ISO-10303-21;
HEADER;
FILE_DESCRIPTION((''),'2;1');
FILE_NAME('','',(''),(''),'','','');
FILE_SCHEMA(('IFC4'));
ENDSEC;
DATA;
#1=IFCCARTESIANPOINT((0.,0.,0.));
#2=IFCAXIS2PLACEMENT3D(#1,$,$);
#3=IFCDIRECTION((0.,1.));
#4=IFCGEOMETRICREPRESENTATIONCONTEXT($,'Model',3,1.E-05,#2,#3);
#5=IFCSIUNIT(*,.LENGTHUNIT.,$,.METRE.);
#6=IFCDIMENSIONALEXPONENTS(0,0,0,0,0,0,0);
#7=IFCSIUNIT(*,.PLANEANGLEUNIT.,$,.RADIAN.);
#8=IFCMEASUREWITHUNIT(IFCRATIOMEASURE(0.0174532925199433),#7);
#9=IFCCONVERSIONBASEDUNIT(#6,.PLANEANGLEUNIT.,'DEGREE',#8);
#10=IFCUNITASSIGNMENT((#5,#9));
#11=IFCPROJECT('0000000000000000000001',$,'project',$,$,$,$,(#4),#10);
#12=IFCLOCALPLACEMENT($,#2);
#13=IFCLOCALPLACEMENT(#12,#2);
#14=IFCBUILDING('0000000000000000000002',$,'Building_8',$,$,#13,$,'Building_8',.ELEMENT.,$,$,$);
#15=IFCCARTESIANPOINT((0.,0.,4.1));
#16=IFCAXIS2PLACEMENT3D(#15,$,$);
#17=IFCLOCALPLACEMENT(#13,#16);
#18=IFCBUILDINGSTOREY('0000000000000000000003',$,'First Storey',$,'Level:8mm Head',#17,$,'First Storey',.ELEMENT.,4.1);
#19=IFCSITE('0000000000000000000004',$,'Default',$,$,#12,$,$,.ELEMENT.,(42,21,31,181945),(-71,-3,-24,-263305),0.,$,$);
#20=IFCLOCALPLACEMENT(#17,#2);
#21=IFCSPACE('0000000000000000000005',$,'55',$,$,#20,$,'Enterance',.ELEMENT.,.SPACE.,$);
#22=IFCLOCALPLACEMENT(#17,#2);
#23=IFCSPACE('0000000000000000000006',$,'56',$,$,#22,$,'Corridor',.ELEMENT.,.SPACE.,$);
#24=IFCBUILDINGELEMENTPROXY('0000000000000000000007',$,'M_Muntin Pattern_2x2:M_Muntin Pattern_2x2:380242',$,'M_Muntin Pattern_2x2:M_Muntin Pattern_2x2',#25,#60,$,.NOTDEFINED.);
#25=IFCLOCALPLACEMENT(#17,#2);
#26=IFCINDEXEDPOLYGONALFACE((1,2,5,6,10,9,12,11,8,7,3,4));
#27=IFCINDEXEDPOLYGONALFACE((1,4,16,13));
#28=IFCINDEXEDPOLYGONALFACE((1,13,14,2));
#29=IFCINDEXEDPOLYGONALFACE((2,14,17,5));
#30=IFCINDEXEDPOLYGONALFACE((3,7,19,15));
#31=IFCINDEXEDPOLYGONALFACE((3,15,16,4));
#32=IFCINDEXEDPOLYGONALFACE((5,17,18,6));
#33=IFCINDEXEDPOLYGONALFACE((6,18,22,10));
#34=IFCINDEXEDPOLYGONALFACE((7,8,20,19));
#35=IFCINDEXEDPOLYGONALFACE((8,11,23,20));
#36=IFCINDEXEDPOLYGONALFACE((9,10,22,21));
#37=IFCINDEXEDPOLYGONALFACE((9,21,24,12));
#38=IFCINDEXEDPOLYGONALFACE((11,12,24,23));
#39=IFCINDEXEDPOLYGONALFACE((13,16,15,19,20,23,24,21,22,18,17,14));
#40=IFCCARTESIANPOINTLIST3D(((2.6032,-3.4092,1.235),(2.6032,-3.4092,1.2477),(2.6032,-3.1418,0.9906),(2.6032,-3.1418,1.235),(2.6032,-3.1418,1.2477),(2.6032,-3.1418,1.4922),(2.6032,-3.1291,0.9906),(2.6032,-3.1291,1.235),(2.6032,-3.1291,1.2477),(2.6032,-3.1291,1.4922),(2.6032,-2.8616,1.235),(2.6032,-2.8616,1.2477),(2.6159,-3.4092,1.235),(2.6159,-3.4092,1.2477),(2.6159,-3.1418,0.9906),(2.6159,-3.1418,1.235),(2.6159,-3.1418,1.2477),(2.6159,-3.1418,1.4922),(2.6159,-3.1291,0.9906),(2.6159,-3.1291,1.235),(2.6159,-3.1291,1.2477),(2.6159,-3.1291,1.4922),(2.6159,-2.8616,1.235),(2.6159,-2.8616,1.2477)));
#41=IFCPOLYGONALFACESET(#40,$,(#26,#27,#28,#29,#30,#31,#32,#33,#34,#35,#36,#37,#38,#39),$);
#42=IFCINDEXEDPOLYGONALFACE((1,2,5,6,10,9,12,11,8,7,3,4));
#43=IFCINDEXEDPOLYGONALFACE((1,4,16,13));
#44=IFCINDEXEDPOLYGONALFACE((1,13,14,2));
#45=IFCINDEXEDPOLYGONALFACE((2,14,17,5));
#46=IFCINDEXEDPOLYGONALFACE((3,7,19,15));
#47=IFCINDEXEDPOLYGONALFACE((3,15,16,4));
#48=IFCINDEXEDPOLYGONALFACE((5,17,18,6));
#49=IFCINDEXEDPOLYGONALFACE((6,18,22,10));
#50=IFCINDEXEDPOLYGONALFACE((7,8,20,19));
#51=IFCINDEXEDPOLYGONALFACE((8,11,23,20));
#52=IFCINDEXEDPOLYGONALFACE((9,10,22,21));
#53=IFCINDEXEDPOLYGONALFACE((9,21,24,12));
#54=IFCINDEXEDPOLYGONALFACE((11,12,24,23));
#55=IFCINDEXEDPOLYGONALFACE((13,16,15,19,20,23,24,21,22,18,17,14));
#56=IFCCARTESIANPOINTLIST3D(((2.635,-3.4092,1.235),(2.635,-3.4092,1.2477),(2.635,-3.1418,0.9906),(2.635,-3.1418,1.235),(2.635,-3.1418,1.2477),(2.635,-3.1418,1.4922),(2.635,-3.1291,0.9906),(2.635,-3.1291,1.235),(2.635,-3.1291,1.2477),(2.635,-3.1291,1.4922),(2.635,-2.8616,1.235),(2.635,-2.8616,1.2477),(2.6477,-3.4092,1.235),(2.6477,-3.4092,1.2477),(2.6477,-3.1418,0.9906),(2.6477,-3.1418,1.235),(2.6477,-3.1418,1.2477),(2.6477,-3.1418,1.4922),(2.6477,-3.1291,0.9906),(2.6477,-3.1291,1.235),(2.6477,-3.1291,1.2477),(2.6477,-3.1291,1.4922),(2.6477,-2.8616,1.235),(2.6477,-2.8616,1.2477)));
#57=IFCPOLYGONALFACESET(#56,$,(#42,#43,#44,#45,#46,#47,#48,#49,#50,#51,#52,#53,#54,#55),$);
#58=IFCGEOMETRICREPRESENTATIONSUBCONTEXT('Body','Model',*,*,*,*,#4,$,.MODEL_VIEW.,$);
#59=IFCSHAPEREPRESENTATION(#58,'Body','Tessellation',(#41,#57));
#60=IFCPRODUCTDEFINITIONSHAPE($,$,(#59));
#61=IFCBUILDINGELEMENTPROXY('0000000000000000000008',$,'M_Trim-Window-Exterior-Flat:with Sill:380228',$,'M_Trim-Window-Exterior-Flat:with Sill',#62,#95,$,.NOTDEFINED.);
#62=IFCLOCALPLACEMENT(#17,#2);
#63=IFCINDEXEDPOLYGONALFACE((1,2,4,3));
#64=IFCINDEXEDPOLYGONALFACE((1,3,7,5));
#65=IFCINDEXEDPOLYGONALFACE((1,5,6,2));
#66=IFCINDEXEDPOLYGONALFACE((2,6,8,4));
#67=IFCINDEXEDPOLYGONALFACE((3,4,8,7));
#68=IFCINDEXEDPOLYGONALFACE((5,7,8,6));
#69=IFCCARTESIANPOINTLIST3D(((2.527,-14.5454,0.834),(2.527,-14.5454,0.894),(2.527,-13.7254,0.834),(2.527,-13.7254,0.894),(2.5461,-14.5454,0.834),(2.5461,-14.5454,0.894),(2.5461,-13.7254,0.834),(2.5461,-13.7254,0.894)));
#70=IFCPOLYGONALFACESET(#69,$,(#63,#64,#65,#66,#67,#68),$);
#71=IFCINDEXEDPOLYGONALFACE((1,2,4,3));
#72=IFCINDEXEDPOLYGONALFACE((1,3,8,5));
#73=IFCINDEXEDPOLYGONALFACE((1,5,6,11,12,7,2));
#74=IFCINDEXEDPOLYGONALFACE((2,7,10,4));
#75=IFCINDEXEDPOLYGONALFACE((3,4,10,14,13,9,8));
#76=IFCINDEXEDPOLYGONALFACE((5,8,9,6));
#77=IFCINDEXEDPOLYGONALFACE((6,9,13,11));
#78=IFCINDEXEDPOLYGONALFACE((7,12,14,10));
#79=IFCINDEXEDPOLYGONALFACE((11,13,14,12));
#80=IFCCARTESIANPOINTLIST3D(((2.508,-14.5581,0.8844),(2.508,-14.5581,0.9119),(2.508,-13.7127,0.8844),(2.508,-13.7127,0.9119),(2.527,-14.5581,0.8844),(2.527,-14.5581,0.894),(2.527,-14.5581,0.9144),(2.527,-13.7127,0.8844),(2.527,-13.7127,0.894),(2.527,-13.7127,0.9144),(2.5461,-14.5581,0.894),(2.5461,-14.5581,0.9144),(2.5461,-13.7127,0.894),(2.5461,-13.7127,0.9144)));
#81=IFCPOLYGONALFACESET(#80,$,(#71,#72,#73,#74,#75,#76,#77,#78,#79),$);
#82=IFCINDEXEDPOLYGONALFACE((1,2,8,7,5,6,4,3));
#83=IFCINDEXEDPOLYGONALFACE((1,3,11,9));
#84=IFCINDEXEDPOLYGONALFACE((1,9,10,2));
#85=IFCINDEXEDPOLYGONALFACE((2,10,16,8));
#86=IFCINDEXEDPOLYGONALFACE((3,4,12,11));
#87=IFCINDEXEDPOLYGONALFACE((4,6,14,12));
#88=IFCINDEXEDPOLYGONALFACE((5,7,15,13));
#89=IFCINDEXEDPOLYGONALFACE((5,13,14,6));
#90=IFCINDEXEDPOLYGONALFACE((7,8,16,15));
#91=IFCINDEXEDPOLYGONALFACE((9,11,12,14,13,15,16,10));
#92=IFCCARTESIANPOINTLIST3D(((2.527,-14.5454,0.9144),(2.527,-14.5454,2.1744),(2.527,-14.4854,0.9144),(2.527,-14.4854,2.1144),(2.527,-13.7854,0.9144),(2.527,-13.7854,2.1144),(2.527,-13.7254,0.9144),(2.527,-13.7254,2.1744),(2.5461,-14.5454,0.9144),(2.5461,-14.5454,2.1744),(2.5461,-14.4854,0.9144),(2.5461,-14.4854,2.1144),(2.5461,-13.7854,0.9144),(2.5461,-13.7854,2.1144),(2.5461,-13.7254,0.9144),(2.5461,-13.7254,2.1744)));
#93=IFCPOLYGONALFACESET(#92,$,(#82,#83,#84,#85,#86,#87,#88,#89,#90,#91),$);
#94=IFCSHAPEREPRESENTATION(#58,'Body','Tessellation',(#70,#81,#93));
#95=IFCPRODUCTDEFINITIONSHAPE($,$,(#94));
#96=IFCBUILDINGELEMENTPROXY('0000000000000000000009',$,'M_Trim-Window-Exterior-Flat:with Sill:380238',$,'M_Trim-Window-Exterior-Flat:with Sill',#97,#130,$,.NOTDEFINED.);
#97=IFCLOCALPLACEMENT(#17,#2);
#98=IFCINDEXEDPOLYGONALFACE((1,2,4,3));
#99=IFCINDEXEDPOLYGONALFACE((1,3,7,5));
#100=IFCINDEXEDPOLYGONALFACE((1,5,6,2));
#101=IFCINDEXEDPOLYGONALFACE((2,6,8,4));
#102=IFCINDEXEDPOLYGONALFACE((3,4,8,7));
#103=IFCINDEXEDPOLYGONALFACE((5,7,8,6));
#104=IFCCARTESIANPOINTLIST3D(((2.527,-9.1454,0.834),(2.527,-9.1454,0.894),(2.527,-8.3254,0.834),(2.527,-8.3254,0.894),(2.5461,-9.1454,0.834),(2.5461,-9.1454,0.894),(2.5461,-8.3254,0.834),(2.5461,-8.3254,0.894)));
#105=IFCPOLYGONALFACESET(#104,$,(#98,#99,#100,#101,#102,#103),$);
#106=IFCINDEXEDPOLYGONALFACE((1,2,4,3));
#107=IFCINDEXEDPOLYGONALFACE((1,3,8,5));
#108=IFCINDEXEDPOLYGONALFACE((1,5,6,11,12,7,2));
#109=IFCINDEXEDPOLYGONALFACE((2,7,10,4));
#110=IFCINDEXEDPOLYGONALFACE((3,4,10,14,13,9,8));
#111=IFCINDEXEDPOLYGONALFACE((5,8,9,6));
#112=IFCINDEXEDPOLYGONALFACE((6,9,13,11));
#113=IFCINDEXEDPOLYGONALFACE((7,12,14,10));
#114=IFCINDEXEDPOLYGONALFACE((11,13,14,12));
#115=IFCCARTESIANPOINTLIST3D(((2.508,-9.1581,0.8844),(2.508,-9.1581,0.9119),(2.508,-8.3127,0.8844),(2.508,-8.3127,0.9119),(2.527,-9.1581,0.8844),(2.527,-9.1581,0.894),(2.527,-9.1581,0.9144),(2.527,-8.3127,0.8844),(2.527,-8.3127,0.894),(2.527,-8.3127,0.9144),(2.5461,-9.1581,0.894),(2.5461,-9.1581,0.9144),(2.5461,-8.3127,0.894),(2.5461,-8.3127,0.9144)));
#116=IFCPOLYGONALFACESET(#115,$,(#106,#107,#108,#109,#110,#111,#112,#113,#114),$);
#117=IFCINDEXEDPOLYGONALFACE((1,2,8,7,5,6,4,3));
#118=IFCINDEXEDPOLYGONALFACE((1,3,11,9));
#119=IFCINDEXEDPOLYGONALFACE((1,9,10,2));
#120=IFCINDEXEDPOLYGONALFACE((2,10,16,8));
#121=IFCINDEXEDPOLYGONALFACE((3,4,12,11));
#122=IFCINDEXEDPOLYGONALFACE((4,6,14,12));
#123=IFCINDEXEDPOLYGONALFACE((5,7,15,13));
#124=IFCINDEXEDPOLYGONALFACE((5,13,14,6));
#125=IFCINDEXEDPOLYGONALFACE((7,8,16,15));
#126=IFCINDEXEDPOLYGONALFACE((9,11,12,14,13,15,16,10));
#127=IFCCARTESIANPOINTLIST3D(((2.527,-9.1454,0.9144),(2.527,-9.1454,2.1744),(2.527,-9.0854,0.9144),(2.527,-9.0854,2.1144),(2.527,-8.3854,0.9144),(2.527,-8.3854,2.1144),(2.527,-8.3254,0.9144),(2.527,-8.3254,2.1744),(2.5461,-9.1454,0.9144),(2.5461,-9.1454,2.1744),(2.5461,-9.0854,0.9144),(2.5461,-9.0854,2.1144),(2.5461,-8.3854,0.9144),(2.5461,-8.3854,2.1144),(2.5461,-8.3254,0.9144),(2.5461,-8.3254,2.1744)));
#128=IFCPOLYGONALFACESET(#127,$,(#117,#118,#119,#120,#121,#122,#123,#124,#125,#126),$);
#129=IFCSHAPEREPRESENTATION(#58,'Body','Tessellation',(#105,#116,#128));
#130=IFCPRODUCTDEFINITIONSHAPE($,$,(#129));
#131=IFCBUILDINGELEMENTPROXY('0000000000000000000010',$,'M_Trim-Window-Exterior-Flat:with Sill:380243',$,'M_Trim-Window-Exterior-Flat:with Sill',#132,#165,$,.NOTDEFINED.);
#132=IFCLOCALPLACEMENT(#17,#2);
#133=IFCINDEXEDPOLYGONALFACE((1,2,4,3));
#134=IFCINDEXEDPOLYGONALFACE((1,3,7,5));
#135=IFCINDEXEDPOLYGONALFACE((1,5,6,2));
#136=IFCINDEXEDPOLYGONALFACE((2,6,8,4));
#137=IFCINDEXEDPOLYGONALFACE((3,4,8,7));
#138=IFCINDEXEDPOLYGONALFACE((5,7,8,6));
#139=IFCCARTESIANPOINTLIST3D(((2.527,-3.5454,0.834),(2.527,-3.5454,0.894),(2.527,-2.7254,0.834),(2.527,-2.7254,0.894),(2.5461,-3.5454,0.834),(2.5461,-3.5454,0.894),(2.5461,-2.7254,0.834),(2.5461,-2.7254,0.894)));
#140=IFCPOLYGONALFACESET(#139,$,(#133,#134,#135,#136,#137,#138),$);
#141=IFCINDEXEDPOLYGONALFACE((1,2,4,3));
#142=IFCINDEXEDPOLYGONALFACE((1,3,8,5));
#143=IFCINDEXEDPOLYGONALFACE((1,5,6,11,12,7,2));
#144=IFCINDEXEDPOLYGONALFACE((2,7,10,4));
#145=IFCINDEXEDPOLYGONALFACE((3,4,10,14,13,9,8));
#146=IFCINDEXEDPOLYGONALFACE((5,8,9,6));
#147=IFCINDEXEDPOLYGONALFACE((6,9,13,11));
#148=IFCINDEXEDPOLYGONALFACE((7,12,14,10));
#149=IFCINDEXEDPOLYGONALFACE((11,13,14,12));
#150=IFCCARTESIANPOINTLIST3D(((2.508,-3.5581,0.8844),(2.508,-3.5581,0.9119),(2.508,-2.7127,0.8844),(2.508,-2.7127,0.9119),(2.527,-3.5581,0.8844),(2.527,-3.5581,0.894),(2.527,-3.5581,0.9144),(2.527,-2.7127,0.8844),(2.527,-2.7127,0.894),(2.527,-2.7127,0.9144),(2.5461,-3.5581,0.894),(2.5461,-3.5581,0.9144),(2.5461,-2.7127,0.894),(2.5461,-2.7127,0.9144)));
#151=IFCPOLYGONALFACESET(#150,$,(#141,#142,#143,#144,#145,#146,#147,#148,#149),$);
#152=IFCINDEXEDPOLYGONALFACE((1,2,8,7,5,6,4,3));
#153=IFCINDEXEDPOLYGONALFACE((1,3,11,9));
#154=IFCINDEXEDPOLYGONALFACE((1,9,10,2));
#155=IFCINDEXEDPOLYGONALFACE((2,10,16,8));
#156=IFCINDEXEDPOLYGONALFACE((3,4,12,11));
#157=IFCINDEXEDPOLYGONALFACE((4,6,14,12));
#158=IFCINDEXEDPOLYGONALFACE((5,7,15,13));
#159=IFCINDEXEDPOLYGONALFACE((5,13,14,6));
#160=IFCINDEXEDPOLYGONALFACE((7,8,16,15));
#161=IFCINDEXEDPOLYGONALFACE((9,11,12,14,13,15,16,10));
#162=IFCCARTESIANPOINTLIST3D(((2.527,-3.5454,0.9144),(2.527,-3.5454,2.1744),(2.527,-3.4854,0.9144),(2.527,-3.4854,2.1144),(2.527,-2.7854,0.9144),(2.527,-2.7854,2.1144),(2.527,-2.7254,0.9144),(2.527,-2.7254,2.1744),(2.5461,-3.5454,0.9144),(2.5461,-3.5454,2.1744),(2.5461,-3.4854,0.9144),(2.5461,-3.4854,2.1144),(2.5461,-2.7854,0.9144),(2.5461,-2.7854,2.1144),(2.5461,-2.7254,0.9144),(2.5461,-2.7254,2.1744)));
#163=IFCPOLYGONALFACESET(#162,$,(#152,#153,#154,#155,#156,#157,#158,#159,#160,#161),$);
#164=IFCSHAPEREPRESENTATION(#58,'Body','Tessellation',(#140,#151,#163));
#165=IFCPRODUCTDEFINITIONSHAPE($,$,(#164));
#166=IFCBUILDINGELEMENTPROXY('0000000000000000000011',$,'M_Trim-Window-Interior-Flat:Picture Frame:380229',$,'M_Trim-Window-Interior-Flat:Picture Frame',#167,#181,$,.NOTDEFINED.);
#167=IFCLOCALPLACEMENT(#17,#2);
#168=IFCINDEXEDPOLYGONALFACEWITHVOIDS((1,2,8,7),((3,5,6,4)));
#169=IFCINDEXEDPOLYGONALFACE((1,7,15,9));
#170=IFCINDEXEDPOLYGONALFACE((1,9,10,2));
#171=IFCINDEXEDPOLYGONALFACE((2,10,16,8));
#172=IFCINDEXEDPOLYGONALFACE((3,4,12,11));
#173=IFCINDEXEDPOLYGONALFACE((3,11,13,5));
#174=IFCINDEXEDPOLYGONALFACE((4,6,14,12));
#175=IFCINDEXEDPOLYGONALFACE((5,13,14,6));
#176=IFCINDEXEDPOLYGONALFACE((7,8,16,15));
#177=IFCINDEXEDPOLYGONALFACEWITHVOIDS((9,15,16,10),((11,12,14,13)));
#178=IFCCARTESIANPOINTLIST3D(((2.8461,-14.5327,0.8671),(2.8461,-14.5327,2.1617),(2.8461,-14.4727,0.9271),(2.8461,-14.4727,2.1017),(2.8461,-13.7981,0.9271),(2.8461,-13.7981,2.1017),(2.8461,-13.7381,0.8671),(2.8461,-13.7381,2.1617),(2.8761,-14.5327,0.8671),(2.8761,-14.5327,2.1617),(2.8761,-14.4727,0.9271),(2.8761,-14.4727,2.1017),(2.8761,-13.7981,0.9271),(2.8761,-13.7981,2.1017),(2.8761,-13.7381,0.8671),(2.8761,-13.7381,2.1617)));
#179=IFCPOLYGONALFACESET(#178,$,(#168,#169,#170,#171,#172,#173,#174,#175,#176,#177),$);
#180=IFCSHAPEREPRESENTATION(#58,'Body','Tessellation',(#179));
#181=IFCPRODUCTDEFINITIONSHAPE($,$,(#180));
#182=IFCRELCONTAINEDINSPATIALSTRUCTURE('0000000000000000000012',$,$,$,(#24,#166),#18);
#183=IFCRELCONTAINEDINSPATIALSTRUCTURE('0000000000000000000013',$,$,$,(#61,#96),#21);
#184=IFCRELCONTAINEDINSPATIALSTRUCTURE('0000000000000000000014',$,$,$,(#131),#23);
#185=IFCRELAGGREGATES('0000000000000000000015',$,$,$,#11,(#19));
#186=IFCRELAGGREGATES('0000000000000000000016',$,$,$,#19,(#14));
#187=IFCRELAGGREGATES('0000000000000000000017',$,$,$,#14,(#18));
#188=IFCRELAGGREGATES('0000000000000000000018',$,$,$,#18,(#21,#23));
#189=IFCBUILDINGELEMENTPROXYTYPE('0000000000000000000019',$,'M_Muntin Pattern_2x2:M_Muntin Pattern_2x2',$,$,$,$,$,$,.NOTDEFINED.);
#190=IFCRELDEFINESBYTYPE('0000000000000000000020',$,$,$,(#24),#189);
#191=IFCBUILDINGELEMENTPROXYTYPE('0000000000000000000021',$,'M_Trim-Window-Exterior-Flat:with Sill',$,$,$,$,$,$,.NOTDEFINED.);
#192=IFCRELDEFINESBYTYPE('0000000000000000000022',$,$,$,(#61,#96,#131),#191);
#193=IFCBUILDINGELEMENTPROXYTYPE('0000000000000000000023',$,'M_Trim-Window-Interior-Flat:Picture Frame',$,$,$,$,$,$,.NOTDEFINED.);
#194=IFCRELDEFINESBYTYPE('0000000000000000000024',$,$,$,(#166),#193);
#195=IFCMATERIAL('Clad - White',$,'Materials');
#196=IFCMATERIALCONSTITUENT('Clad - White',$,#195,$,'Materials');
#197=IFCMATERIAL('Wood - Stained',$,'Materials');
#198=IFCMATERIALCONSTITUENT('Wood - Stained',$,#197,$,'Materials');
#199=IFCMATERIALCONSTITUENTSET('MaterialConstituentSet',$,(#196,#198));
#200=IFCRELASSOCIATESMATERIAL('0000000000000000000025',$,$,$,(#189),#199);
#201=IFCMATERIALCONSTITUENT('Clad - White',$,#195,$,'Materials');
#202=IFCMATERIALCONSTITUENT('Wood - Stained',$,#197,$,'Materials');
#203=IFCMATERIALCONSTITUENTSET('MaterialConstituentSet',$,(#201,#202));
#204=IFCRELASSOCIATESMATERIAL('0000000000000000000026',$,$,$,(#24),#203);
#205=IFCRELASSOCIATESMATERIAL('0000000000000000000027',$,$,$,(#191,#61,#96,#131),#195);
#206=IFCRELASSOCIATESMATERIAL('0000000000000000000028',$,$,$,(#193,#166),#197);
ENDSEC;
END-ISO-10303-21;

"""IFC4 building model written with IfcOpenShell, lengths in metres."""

from ifc_helpers import new_model, entity, si_unit, converted_unit, direction, frame, origin, place, context, subcontext, project, spatial, indexed_curve, outline, extrude, source, transform, mapped, material, constituent, constituent_set, type_object, type_shapes, element, save


model = new_model("IFC4")

# Units and contexts
model_context = context("Model", 3, precision=1e-05, world=origin(), true_north=direction((0.0, 1.0)))
body_context = subcontext(model_context, "Body", "Model", "MODEL_VIEW")
ifc_project = project(units=[si_unit("LENGTHUNIT", "METRE"), converted_unit("PLANEANGLEUNIT", "DEGREE", entity("IfcRatioMeasure", 0.0174532925199433), si_unit("PLANEANGLEUNIT", "RADIAN"), dimensions=[0, 0, 0, 0, 0, 0, 0])], contexts=[model_context])

# Site, building, storey
site_placement = place(None, origin())
site = spatial("IfcSite", under=ifc_project, at=site_placement, Name="Default", CompositionType="ELEMENT", RefLatitude=(42, 21, 31, 181945), RefLongitude=(-71, -3, -24, -263305), RefElevation=0.0)
building_placement = place(site_placement, origin())
building = spatial("IfcBuilding", under=site, at=building_placement, Name="Building_8", LongName="Building_8", CompositionType="ELEMENT")
storey_placement = place(building_placement, frame((0.0, 0.0, 4.1)))
storey = spatial("IfcBuildingStorey", under=building, at=storey_placement, Name="First Storey", ObjectType="Level:8mm Head", LongName="First Storey", CompositionType="ELEMENT", Elevation=4.1)

# Building element proxy
ifc_material_1 = material(Name="Clad - White", Category="Materials")
ifc_material_2 = material(Name="Wood - Stained", Category="Materials")
ifc_constituent_1 = constituent(ifc_material_1, Name="Clad - White", Category="Materials")
ifc_constituent_2 = constituent(ifc_material_2, Name="Wood - Stained", Category="Materials")
ifc_constituent_set_1 = constituent_set(constituents=[ifc_constituent_1, ifc_constituent_2], Name="MaterialConstituentSet")
building_element_proxy_type_1 = type_object("IfcBuildingElementProxyType", Name="M_Muntin Pattern_2x2:M_Muntin Pattern_2x2", PredefinedType="NOTDEFINED", material=ifc_constituent_set_1)
shared_shape_1 = source(origin(), body_context, "Body", "SweptSolid", [
    extrude(outline(indexed_curve([(0.0064, -0.0064), (0.2508, -0.0064), (0.2508, 0.0063), (0.0064, 0.0063), (0.0064, 0.2738), (-0.0063, 0.2738), (-0.0063, 0.0063), (-0.2508, 0.0063), (-0.2508, -0.0064), (-0.0063, -0.0064), (-0.0063, -0.2738), (0.0064, -0.2738), (0.0064, -0.0064)], self_intersect=False)), frame((0.0, 0.0095, 0.2508), z_axis=(0.0, 1.0, 0.0), x_axis=(0.0, 0.0, 1.0)), (0.0, 0.0, 1.0), 0.0127),
    extrude(outline(indexed_curve([(0.0064, -0.0064), (0.2508, -0.0064), (0.2508, 0.0063), (0.0064, 0.0063), (0.0064, 0.2738), (-0.0063, 0.2738), (-0.0063, 0.0063), (-0.2508, 0.0063), (-0.2508, -0.0064), (-0.0063, -0.0064), (-0.0063, -0.2738), (0.0064, -0.2738), (0.0064, -0.0064)], self_intersect=False)), frame((0.0, -0.0222, 0.2508), z_axis=(0.0, 1.0, 0.0), x_axis=(0.0, 0.0, 1.0)), (0.0, 0.0, 1.0), 0.0127),
])
type_shapes(building_element_proxy_type_1, [shared_shape_1])
ifc_constituent_3 = constituent(ifc_material_1, Name="Clad - White", Category="Materials")
ifc_constituent_4 = constituent(ifc_material_2, Name="Wood - Stained", Category="Materials")
ifc_constituent_set_2 = constituent_set(constituents=[ifc_constituent_3, ifc_constituent_4], Name="MaterialConstituentSet")
proxy_1_placement = place(storey_placement, frame((2.6255, -3.1354, 0.9906), z_axis=(0.0, 0.0, 1.0), x_axis=(0.0, 1.0, 0.0)))
element("IfcBuildingElementProxy", 1, at=proxy_1_placement, inside=storey, type_object=building_element_proxy_type_1, material=ifc_constituent_set_2, Name="M_Muntin Pattern_2x2:M_Muntin Pattern_2x2:380242", ObjectType="M_Muntin Pattern_2x2:M_Muntin Pattern_2x2", PredefinedType="NOTDEFINED", context=body_context, shape_type="MappedRepresentation", body=[
    mapped(shared_shape_1, transform((0.0, 0.0, 0.0), scale=1.0)),
])

# Shared definitions
space_1_placement = place(storey_placement, origin())
space_1 = spatial("IfcSpace", under=storey, at=space_1_placement, Name="55", LongName="Enterance", CompositionType="ELEMENT", PredefinedType="SPACE")

# Building element proxies
building_element_proxy_type_2 = type_object("IfcBuildingElementProxyType", Name="M_Trim-Window-Exterior-Flat:with Sill", PredefinedType="NOTDEFINED", material=ifc_material_1)
shared_shape_2 = source(origin(), body_context, "Body", "SweptSolid", [
    extrude(outline(indexed_curve([(-0.41, -0.03), (0.41, -0.03), (0.41, 0.03), (-0.41, 0.03), (-0.41, -0.03)], self_intersect=False)), frame((0.0, -1.2504, 0.0), z_axis=(0.0, 0.0, 1.0), x_axis=(-1.0, 0.0, 0.0)), (0.0, 0.0, 1.0), 0.0191),
    extrude(outline(indexed_curve([(-0.019, -0.0152), (0.0, -0.0152), (0.0, -0.0057), (0.019, -0.0057), (0.019, 0.0148), (0.0, 0.0148), (-0.019, 0.0123), (-0.019, -0.0152)], self_intersect=False)), frame((-0.4227, -1.2148, 0.019), z_axis=(1.0, 0.0, 0.0), x_axis=(0.0, 0.0, -1.0)), (0.0, 0.0, 1.0), 0.8454),
    extrude(outline(indexed_curve([(-0.645, -0.41), (0.615, -0.41), (0.615, -0.35), (-0.585, -0.35), (-0.585, 0.35), (0.615, 0.35), (0.615, 0.41), (-0.645, 0.41), (-0.645, -0.41)], self_intersect=False)), frame((0.0, -0.585, 0.0), z_axis=(0.0, 0.0, 1.0), x_axis=(0.0, -1.0, 0.0)), (0.0, 0.0, 1.0), 0.0191),
])
type_shapes(building_element_proxy_type_2, [shared_shape_2])
for number, where, z_axis, x_axis, name in (
    (2, (2.5461, -14.1354, 2.1144), (-1.0, 0.0, 0.0), (0.0, -1.0, 0.0), "M_Trim-Window-Exterior-Flat:with Sill:380228"),
    (3, (2.5461, -8.7354, 2.1144), (-1.0, 0.0, 0.0), (0.0, -1.0, 0.0), "M_Trim-Window-Exterior-Flat:with Sill:380238"),
):
    element("IfcBuildingElementProxy", number, at=place(space_1_placement, frame(where, z_axis=z_axis, x_axis=x_axis)), inside=space_1, type_object=building_element_proxy_type_2, material=ifc_material_1, Name=name, ObjectType="M_Trim-Window-Exterior-Flat:with Sill", PredefinedType="NOTDEFINED", context=body_context, shape_type="MappedRepresentation", body=[
        mapped(shared_shape_2, transform((0.0, 0.0, 0.0), scale=1.0)),
    ])

# Shared definitions
space_2_placement = place(storey_placement, origin())
space_2 = spatial("IfcSpace", under=storey, at=space_2_placement, Name="56", LongName="Corridor", CompositionType="ELEMENT", PredefinedType="SPACE")

# Building element proxies
proxy_2_placement = place(space_2_placement, frame((2.5461, -3.1354, 2.1144), z_axis=(-1.0, 0.0, 0.0), x_axis=(0.0, -1.0, 0.0)))
element("IfcBuildingElementProxy", 4, at=proxy_2_placement, inside=space_2, type_object=building_element_proxy_type_2, material=ifc_material_1, Name="M_Trim-Window-Exterior-Flat:with Sill:380243", ObjectType="M_Trim-Window-Exterior-Flat:with Sill", PredefinedType="NOTDEFINED", context=body_context, shape_type="MappedRepresentation", body=[
    mapped(shared_shape_2, transform((0.0, 0.0, 0.0), scale=1.0)),
])
building_element_proxy_type_3 = type_object("IfcBuildingElementProxyType", Name="M_Trim-Window-Interior-Flat:Picture Frame", PredefinedType="NOTDEFINED", material=ifc_material_2)
shared_shape_3 = source(origin(), body_context, "Body", "SweptSolid", [
    extrude(outline(indexed_curve([(-0.3973, -0.6473), (0.3973, -0.6473), (0.3973, 0.6473), (-0.3973, 0.6473), (-0.3973, -0.6473)], self_intersect=False), holes=[indexed_curve([(-0.3373, -0.5873), (-0.3373, 0.5873), (0.3373, 0.5873), (0.3373, -0.5873), (-0.3373, -0.5873)], self_intersect=False)]), frame((0.0, -0.6, 0.0), z_axis=(0.0, 0.0, 1.0), x_axis=(-1.0, 0.0, 0.0)), (0.0, 0.0, 1.0), 0.03),
])
type_shapes(building_element_proxy_type_3, [shared_shape_3])
for number, where, z_axis, x_axis, name in (
    (5, (2.8461, -14.1354, 2.1144), (1.0, 0.0, 0.0), (0.0, 1.0, 0.0), "M_Trim-Window-Interior-Flat:Picture Frame:380229"),
):
    element("IfcBuildingElementProxy", number, at=place(storey_placement, frame(where, z_axis=z_axis, x_axis=x_axis)), inside=storey, type_object=building_element_proxy_type_3, material=ifc_material_2, Name=name, ObjectType="M_Trim-Window-Interior-Flat:Picture Frame", PredefinedType="NOTDEFINED", context=body_context, shape_type="MappedRepresentation", body=[
        mapped(shared_shape_3, transform((0.0, 0.0, 0.0), scale=1.0)),
    ])

save(model, "model.ifc")
